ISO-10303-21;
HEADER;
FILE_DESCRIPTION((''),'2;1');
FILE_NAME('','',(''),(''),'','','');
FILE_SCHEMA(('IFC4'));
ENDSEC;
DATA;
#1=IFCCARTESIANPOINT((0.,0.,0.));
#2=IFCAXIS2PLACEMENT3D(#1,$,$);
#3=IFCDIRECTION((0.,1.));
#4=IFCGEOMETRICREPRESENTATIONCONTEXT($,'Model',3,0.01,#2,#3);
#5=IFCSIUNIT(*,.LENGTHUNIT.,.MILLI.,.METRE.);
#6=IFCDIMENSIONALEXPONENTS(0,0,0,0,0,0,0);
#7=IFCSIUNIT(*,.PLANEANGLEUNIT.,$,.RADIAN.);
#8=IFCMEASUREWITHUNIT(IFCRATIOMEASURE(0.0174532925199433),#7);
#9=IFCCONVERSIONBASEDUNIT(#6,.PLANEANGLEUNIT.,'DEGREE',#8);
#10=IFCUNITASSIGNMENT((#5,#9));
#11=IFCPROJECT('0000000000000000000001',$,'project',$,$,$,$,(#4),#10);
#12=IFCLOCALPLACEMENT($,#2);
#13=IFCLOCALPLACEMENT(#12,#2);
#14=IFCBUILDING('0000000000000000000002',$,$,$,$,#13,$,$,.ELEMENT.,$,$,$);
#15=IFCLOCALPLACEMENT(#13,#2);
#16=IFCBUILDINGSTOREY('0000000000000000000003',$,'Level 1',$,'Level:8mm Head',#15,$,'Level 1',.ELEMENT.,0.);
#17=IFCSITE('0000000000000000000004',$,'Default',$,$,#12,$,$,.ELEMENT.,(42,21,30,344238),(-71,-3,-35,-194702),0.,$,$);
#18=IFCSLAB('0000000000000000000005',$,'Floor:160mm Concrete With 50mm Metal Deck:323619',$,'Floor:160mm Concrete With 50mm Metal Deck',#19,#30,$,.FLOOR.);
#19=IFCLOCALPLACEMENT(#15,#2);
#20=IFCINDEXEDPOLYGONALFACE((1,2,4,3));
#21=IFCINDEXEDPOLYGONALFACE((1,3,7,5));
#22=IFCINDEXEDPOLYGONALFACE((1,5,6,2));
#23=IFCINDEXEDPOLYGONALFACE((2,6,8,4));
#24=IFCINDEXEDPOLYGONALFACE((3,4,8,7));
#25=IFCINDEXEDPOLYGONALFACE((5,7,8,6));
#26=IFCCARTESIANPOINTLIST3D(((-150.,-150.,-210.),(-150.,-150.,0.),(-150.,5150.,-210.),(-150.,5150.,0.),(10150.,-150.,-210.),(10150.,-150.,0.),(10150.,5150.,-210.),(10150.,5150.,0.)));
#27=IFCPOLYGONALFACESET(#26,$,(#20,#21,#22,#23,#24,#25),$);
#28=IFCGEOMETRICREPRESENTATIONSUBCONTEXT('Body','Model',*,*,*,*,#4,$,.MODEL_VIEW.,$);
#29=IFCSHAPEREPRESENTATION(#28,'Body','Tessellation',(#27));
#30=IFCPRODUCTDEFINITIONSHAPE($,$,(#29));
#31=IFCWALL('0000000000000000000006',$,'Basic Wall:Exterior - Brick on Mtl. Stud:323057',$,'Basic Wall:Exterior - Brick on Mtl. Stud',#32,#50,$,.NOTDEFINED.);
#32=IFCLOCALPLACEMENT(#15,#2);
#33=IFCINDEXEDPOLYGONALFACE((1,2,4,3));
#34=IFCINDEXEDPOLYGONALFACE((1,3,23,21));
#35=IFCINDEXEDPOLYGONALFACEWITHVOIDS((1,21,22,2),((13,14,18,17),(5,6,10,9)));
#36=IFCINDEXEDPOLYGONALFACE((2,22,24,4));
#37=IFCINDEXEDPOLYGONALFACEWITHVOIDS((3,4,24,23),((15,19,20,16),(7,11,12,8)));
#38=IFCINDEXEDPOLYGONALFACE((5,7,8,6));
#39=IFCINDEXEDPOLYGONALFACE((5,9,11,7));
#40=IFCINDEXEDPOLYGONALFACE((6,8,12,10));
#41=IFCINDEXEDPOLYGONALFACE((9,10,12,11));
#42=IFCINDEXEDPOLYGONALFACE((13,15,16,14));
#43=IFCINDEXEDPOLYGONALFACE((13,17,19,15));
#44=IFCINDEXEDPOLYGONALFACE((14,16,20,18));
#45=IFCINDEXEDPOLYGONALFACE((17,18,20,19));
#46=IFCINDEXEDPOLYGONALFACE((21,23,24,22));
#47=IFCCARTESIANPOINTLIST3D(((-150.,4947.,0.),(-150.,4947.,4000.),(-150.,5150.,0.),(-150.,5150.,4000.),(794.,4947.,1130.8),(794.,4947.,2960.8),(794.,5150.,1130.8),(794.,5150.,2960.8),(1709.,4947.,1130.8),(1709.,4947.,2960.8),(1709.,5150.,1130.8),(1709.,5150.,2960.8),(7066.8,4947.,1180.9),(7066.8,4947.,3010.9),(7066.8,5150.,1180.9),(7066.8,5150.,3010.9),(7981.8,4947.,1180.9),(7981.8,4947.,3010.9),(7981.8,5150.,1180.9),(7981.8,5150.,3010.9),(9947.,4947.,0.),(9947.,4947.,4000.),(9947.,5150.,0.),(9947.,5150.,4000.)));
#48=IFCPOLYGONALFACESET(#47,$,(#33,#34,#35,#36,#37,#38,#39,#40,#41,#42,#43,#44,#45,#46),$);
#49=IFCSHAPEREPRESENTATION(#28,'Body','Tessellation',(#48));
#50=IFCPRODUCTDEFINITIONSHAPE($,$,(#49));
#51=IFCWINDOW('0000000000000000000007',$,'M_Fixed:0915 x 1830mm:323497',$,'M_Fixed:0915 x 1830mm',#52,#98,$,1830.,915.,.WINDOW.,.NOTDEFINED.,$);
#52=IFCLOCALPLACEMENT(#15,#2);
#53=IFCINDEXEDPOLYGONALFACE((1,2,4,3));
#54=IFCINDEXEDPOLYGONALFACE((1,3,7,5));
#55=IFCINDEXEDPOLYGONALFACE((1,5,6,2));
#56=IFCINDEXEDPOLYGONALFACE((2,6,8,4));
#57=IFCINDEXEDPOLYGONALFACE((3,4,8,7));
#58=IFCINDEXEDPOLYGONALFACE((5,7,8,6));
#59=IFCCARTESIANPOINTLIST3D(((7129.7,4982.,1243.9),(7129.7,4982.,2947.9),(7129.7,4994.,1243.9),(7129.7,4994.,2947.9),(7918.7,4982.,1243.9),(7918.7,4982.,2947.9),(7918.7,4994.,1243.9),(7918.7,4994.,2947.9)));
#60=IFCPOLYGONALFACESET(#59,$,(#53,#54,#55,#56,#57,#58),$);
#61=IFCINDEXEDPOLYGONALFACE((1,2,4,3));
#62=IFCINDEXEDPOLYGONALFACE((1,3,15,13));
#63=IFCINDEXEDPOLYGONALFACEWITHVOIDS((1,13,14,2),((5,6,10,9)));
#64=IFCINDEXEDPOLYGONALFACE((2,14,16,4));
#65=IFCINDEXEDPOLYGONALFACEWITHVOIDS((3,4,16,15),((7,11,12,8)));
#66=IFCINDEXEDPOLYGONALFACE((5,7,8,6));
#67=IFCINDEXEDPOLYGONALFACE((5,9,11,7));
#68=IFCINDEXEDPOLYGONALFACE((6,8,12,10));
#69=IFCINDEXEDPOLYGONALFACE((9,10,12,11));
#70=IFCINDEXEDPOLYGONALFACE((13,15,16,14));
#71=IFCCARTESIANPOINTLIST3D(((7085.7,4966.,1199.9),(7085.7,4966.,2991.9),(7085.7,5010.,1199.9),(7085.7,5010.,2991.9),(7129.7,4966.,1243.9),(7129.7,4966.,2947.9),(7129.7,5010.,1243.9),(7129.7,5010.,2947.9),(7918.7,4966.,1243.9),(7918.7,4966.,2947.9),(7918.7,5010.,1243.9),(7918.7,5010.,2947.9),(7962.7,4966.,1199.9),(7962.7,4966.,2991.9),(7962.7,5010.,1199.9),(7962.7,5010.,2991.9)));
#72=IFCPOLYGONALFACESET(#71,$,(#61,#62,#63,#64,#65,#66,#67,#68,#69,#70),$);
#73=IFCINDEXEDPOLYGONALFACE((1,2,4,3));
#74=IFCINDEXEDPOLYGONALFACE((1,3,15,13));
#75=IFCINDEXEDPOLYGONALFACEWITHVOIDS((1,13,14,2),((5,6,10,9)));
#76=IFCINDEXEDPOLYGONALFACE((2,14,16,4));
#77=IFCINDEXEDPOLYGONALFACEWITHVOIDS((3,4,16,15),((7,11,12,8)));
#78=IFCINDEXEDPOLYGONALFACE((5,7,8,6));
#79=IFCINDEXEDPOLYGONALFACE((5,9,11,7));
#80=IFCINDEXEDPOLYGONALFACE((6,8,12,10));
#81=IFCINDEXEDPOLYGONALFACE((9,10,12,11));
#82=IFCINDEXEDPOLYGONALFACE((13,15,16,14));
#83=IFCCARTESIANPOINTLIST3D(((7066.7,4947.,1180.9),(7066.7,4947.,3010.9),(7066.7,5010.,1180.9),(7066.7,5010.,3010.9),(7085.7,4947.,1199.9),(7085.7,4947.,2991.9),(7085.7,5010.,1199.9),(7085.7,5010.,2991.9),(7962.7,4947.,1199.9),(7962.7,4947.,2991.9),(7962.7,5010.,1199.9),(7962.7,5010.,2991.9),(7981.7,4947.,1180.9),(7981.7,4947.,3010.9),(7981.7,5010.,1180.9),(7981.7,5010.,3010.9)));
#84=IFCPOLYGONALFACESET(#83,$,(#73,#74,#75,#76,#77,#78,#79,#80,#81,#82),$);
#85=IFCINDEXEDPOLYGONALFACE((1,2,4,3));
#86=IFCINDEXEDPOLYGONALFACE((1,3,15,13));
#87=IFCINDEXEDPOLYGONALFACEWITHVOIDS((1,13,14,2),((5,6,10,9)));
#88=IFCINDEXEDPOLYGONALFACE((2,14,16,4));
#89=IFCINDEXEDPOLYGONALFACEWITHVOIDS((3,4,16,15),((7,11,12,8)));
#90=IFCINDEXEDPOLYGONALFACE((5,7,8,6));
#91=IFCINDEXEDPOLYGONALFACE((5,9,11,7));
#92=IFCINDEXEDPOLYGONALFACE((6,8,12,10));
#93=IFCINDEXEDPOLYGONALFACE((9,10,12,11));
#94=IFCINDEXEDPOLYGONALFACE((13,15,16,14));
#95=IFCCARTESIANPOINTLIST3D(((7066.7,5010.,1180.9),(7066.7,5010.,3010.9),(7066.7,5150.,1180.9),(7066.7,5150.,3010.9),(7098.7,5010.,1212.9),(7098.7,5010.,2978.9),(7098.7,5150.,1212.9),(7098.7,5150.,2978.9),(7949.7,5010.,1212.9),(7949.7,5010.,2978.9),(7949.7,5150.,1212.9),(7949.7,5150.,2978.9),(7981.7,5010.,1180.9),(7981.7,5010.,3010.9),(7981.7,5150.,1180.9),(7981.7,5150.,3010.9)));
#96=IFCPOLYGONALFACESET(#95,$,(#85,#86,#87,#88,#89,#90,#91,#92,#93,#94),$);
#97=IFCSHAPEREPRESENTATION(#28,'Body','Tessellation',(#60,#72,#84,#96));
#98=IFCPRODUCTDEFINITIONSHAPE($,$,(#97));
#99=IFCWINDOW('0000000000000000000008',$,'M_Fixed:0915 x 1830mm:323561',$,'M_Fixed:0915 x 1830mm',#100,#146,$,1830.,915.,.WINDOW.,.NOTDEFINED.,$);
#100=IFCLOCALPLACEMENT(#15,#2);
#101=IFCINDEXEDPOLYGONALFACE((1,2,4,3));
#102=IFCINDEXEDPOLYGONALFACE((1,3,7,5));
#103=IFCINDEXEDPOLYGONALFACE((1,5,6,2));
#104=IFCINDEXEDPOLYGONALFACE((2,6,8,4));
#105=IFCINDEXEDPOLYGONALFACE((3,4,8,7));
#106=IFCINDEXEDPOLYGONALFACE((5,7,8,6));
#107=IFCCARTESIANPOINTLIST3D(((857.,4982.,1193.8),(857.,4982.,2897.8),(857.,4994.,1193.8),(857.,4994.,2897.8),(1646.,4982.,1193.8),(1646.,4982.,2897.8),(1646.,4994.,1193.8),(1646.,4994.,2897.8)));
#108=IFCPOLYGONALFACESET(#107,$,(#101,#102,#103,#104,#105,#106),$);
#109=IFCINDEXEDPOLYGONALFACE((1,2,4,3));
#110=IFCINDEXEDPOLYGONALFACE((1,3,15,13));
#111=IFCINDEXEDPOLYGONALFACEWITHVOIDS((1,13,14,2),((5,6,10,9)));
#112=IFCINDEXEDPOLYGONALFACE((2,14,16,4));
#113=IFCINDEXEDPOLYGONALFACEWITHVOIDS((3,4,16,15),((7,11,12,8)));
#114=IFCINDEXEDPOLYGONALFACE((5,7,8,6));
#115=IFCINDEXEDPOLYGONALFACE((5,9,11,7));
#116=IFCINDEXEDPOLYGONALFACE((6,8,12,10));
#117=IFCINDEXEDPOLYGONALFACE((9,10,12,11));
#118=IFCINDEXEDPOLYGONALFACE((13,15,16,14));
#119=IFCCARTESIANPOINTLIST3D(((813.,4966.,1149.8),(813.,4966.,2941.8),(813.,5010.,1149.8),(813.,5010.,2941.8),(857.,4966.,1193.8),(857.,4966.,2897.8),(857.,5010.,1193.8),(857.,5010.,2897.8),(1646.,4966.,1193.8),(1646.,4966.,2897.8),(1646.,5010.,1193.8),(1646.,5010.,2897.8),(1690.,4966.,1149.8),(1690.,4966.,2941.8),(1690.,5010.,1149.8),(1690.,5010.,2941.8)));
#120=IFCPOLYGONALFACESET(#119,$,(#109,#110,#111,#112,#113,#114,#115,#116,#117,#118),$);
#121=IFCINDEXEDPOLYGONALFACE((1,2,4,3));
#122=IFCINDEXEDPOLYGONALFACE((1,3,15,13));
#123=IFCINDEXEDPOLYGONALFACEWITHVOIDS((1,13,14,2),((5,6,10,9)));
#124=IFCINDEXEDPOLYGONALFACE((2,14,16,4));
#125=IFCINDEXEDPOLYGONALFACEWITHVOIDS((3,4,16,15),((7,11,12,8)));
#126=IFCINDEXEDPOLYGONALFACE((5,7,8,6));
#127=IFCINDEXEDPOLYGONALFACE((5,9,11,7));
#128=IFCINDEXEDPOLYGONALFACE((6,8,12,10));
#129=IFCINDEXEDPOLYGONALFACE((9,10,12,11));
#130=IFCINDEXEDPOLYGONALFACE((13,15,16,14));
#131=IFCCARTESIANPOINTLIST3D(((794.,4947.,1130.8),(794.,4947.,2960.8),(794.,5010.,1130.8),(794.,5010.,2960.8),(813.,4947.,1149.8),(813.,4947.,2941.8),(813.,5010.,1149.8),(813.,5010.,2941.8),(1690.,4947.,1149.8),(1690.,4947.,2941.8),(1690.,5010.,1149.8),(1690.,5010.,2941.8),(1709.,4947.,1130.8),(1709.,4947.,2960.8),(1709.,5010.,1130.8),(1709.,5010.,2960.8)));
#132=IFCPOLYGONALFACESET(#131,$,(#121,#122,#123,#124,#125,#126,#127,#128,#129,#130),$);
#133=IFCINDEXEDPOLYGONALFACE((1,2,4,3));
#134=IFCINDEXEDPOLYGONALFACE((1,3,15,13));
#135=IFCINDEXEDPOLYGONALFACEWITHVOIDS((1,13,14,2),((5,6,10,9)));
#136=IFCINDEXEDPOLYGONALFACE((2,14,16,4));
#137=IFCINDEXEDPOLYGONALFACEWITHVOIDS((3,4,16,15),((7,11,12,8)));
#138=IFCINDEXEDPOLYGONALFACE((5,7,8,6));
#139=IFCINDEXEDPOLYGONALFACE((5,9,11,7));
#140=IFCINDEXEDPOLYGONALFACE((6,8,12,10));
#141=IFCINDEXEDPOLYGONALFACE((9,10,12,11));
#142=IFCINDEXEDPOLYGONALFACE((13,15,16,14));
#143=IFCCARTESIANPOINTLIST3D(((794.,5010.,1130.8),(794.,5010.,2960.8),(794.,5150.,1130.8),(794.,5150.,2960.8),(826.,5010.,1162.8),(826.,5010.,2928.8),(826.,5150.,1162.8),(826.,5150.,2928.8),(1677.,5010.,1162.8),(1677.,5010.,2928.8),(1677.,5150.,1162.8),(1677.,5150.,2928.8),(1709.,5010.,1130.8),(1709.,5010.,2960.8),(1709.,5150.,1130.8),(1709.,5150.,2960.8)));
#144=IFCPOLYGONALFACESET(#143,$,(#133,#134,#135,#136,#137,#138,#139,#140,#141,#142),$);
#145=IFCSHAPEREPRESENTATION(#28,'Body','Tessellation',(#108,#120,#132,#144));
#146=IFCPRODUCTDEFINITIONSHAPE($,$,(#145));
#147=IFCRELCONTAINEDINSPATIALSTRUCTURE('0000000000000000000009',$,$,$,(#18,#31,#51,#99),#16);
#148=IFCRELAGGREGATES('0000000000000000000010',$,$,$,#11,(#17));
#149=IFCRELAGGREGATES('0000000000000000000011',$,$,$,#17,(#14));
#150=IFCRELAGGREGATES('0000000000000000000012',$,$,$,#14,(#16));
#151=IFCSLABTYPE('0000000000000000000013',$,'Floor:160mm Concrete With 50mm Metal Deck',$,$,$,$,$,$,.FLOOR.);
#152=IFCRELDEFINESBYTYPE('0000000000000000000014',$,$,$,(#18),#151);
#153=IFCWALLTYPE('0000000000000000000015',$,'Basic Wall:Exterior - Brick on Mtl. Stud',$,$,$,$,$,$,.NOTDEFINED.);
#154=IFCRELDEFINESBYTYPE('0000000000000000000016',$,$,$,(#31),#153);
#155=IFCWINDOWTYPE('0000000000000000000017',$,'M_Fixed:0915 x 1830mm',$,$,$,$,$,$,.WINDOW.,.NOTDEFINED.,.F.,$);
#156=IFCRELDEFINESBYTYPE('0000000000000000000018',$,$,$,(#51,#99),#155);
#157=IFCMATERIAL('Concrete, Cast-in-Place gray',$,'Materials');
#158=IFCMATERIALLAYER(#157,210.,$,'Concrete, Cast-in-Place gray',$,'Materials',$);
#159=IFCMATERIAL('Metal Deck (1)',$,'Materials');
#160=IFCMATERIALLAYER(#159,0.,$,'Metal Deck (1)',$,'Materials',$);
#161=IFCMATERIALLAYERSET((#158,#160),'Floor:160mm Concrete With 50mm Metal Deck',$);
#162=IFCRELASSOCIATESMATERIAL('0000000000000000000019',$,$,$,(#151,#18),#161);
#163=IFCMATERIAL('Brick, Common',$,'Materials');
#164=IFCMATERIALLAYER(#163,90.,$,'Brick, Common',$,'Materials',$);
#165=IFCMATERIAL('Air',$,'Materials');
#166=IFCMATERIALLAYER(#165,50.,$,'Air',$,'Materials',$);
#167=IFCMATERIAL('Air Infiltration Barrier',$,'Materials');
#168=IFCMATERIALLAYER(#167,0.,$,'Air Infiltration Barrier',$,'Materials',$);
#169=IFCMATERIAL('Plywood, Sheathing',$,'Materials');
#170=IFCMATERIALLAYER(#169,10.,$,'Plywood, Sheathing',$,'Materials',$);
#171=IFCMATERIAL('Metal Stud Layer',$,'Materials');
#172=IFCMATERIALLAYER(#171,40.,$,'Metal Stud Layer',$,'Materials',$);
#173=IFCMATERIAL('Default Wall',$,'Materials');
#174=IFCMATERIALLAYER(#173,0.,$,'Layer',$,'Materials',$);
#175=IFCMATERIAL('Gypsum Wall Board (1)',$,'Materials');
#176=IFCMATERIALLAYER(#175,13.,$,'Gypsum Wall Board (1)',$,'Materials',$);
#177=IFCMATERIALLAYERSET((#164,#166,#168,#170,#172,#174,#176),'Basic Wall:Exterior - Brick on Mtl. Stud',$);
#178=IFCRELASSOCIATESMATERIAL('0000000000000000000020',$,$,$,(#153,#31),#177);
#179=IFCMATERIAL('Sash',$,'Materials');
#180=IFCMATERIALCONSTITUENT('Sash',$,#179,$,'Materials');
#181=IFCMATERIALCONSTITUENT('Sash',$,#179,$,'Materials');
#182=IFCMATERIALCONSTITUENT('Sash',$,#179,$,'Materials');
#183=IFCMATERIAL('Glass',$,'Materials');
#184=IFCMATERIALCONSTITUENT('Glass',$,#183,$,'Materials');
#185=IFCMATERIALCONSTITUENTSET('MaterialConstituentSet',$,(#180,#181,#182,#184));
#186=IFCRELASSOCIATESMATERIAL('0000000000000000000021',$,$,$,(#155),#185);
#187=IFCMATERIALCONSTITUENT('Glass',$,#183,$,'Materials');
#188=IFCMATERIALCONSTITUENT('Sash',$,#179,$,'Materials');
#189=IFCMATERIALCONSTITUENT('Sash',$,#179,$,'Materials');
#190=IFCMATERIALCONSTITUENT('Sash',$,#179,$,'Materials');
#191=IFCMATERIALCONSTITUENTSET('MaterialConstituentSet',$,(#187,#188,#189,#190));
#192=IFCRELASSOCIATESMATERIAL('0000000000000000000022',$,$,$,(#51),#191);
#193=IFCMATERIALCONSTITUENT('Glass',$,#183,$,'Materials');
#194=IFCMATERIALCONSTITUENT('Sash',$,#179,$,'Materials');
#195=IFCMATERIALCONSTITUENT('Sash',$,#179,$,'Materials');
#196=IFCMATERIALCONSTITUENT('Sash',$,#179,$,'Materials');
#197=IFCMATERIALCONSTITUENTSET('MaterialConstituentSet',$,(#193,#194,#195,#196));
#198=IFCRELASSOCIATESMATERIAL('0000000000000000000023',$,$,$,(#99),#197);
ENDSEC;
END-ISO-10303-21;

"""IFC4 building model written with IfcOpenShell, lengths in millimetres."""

from ifc_helpers import new_model, entity, si_unit, converted_unit, direction, frame, frame_2d, origin, place, context, subcontext, project, spatial, polyline, rectangle, outline, extrude, source, transform, mapped, material, layer, layer_set, layer_usage, constituent, constituent_set, type_object, type_shapes, element, fill, save


model = new_model("IFC4")

# Units and contexts
model_context = context("Model", 3, precision=0.01, world=origin(), true_north=direction((0.0, 1.0)))
body_context = subcontext(model_context, "Body", "Model", "MODEL_VIEW")
ifc_project = project(units=[si_unit("LENGTHUNIT", "METRE", prefix="MILLI"), converted_unit("PLANEANGLEUNIT", "DEGREE", entity("IfcRatioMeasure", 0.0174532925199433), si_unit("PLANEANGLEUNIT", "RADIAN"), dimensions=[0, 0, 0, 0, 0, 0, 0])], contexts=[model_context])

# Site, building, storey
site_placement = place(None, origin())
site = spatial("IfcSite", under=ifc_project, at=site_placement, Name="Default", CompositionType="ELEMENT", RefLatitude=(42, 21, 30, 344238), RefLongitude=(-71, -3, -35, -194702), RefElevation=0.0)
building_placement = place(site_placement, origin())
building = spatial("IfcBuilding", under=site, at=building_placement, CompositionType="ELEMENT")
storey_placement = place(building_placement, origin())
storey = spatial("IfcBuildingStorey", under=building, at=storey_placement, Name="Level 1", ObjectType="Level:8mm Head", LongName="Level 1", CompositionType="ELEMENT", Elevation=0.0)

# Slab
ifc_material_1 = material(Name="Concrete, Cast-in-Place gray", Category="Materials")
ifc_layer_1 = layer(ifc_material_1, 210.0, Name="Concrete, Cast-in-Place gray", Category="Materials")
ifc_material_2 = material(Name="Metal Deck (1)", Category="Materials")
ifc_layer_2 = layer(ifc_material_2, 0.0, Name="Metal Deck (1)", Category="Materials")
ifc_layer_set_1 = layer_set([ifc_layer_1, ifc_layer_2], Name="Floor:160mm Concrete With 50mm Metal Deck")
ifc_layer_usage_1 = layer_usage(ifc_layer_set_1, "AXIS3", "POSITIVE", 0.0)
slab_type = type_object("IfcSlabType", Name="Floor:160mm Concrete With 50mm Metal Deck", PredefinedType="FLOOR", material=ifc_layer_set_1)
slab_placement = place(storey_placement, origin())
element("IfcSlab", 1, at=slab_placement, inside=storey, type_object=slab_type, material=ifc_layer_usage_1, Name="Floor:160mm Concrete With 50mm Metal Deck:323619", ObjectType="Floor:160mm Concrete With 50mm Metal Deck", PredefinedType="FLOOR", context=body_context, shape_type="SweptSolid", body=[
    extrude(rectangle(XDim=5300.0, YDim=10300.0, at=frame_2d((0.0, 0.0), x_axis=(1.0, 0.0))), frame((5000.0, 2500.0, 0.0), z_axis=(0.0, 0.0, -1.0), x_axis=(0.0, 1.0, 0.0)), (0.0, 0.0, 1.0), 210.0),
])

# Wall, openings, windows
ifc_material_3 = material(Name="Brick, Common", Category="Materials")
ifc_layer_3 = layer(ifc_material_3, 90.0, Name="Brick, Common", Category="Materials")
ifc_material_4 = material(Name="Air", Category="Materials")
ifc_layer_4 = layer(ifc_material_4, 50.0, Name="Air", Category="Materials")
ifc_material_5 = material(Name="Air Infiltration Barrier", Category="Materials")
ifc_layer_5 = layer(ifc_material_5, 0.0, Name="Air Infiltration Barrier", Category="Materials")
ifc_material_6 = material(Name="Plywood, Sheathing", Category="Materials")
ifc_layer_6 = layer(ifc_material_6, 10.0, Name="Plywood, Sheathing", Category="Materials")
ifc_material_7 = material(Name="Metal Stud Layer", Category="Materials")
ifc_layer_7 = layer(ifc_material_7, 40.0, Name="Metal Stud Layer", Category="Materials")
ifc_material_8 = material(Name="Default Wall", Category="Materials")
ifc_layer_8 = layer(ifc_material_8, 0.0, Name="Layer", Category="Materials")
ifc_material_9 = material(Name="Gypsum Wall Board (1)", Category="Materials")
ifc_layer_9 = layer(ifc_material_9, 13.0, Name="Gypsum Wall Board (1)", Category="Materials")
ifc_layer_set_2 = layer_set([ifc_layer_3, ifc_layer_4, ifc_layer_5, ifc_layer_6, ifc_layer_7, ifc_layer_8, ifc_layer_9], Name="Basic Wall:Exterior - Brick on Mtl. Stud")
ifc_layer_usage_2 = layer_usage(ifc_layer_set_2, "AXIS2", "NEGATIVE", 101.5)
wall_type_1 = type_object("IfcWallType", Name="Basic Wall:Exterior - Brick on Mtl. Stud", PredefinedType="NOTDEFINED", material=ifc_layer_set_2)
wall_1_placement = place(storey_placement, frame((-150.0, 5048.5, 0.0)))
wall_1 = element("IfcWall", 2, at=wall_1_placement, inside=storey, type_object=wall_type_1, material=ifc_layer_usage_2, Name="Basic Wall:Exterior - Brick on Mtl. Stud:323057", ObjectType="Basic Wall:Exterior - Brick on Mtl. Stud", PredefinedType="NOTDEFINED", context=body_context, shape_type="SweptSolid", body=[
    extrude(rectangle(XDim=10097.0, YDim=203.0, at=frame_2d((5048.5, 0.0), x_axis=(-1.0, 0.0))), origin(), (0.0, 0.0, 1.0), 4000.0),
])
opening_1_placement = place(wall_1_placement, frame((8131.8, 101.5, 1180.9)))
opening_1 = element("IfcOpeningElement", 3, at=opening_1_placement, cuts=wall_1, ObjectType="Opening", PredefinedType="OPENING", context=body_context, shape_type="SweptSolid", body=[
    extrude(rectangle(XDim=1830.0, YDim=915.0, at=frame_2d((915.0, 457.5), x_axis=(1.0, 0.0))), frame((0.0, 0.0, 0.0), z_axis=(0.0, -1.0, 0.0), x_axis=(0.0, 0.0, 1.0)), (0.0, 0.0, 1.0), 203.0),
])
opening_2_placement = place(wall_1_placement, frame((1859.0, 101.5, 1130.8)))
opening_2 = element("IfcOpeningElement", 4, at=opening_2_placement, cuts=wall_1, ObjectType="Opening", PredefinedType="OPENING", context=body_context, shape_type="SweptSolid", body=[
    extrude(rectangle(XDim=1830.0, YDim=915.0, at=frame_2d((915.0, 457.5), x_axis=(1.0, 0.0))), frame((0.0, 0.0, 0.0), z_axis=(0.0, -1.0, 0.0), x_axis=(0.0, 0.0, 1.0)), (0.0, 0.0, 1.0), 203.0),
])
ifc_material_10 = material(Name="Glass", Category="Materials")
ifc_constituent_1 = constituent(ifc_material_10, Name="Glass", Category="Materials")
ifc_material_11 = material(Name="Sash", Category="Materials")
ifc_constituent_2 = constituent(ifc_material_11, Name="Sash", Category="Materials")
ifc_constituent_3 = constituent(ifc_material_11, Name="Sash", Category="Materials")
ifc_constituent_4 = constituent(ifc_material_11, Name="Sash", Category="Materials")
ifc_constituent_set_1 = constituent_set(constituents=[ifc_constituent_1, ifc_constituent_2, ifc_constituent_3, ifc_constituent_4], Name="MaterialConstituentSet")
ifc_constituent_5 = constituent(ifc_material_11, Name="Sash", Category="Materials")
ifc_constituent_6 = constituent(ifc_material_11, Name="Sash", Category="Materials")
ifc_constituent_7 = constituent(ifc_material_11, Name="Sash", Category="Materials")
ifc_constituent_8 = constituent(ifc_material_10, Name="Glass", Category="Materials")
ifc_constituent_set_2 = constituent_set(constituents=[ifc_constituent_5, ifc_constituent_6, ifc_constituent_7, ifc_constituent_8], Name="MaterialConstituentSet")
window_type = type_object("IfcWindowType", Name="M_Fixed:0915 x 1830mm", ParameterTakesPrecedence=False, PartitioningType="NOTDEFINED", PredefinedType="WINDOW", material=ifc_constituent_set_2)
shared_shape_1 = source(origin(), body_context, "Body", "SweptSolid", [
    extrude(rectangle(XDim=12.0, YDim=789.0, at=frame_2d((0.0, 0.0), x_axis=(1.0, 0.0))), frame((457.5, 162.0, 63.0), z_axis=(0.0, 0.0, 1.0), x_axis=(0.0, -1.0, 0.0)), (0.0, 0.0, 1.0), 1704.0),
    extrude(outline(polyline([(-438.5, -896.0), (438.5, -896.0), (438.5, 896.0), (-438.5, 896.0), (-438.5, -896.0)]), holes=[polyline([(-394.5, -852.0), (-394.5, 852.0), (394.5, 852.0), (394.5, -852.0), (-394.5, -852.0)])]), frame((457.5, 140.0, 915.0), z_axis=(0.0, 1.0, 0.0), x_axis=(1.0, 0.0, 0.0)), (0.0, 0.0, 1.0), 44.0),
    extrude(outline(polyline([(-457.5, -915.0), (457.5, -915.0), (457.5, 915.0), (-457.5, 915.0), (-457.5, -915.0)]), holes=[polyline([(-438.5, -896.0), (-438.5, 896.0), (438.5, 896.0), (438.5, -896.0), (-438.5, -896.0)])]), frame((457.5, 140.0, 915.0), z_axis=(0.0, 1.0, 0.0), x_axis=(1.0, 0.0, 0.0)), (0.0, 0.0, 1.0), 63.0),
    extrude(outline(polyline([(-457.5, -915.0), (457.5, -915.0), (457.5, 915.0), (-457.5, 915.0), (-457.5, -915.0)]), holes=[polyline([(-425.5, -883.0), (-425.5, 883.0), (425.5, 883.0), (425.5, -883.0), (-425.5, -883.0)])]), frame((457.5, 0.0, 915.0), z_axis=(0.0, 1.0, 0.0), x_axis=(1.0, 0.0, 0.0)), (0.0, 0.0, 1.0), 140.0),
])
type_shapes(window_type, [shared_shape_1])
window_1_placement = place(opening_1_placement, frame((0.0, 0.0, 0.0), z_axis=(0.0, 0.0, 1.0), x_axis=(-1.0, 0.0, 0.0)))
window_1 = element("IfcWindow", 5, at=window_1_placement, inside=storey, type_object=window_type, material=ifc_constituent_set_1, Name="M_Fixed:0915 x 1830mm:323497", ObjectType="M_Fixed:0915 x 1830mm", OverallHeight=1830.0, OverallWidth=915.0, PartitioningType="NOTDEFINED", PredefinedType="WINDOW", context=body_context, shape_type="MappedRepresentation", body=[
    mapped(shared_shape_1, transform((0.0, 0.0, 0.0), scale=1.0)),
])
fill(opening_1, window_1)
ifc_constituent_9 = constituent(ifc_material_10, Name="Glass", Category="Materials")
ifc_constituent_10 = constituent(ifc_material_11, Name="Sash", Category="Materials")
ifc_constituent_11 = constituent(ifc_material_11, Name="Sash", Category="Materials")
ifc_constituent_12 = constituent(ifc_material_11, Name="Sash", Category="Materials")
ifc_constituent_set_3 = constituent_set(constituents=[ifc_constituent_9, ifc_constituent_10, ifc_constituent_11, ifc_constituent_12], Name="MaterialConstituentSet")
window_2_placement = place(opening_2_placement, frame((0.0, 0.0, 0.0), z_axis=(0.0, 0.0, 1.0), x_axis=(-1.0, 0.0, 0.0)))
window_2 = element("IfcWindow", 6, at=window_2_placement, inside=storey, type_object=window_type, material=ifc_constituent_set_3, Name="M_Fixed:0915 x 1830mm:323561", ObjectType="M_Fixed:0915 x 1830mm", OverallHeight=1830.0, OverallWidth=915.0, PartitioningType="NOTDEFINED", PredefinedType="WINDOW", context=body_context, shape_type="MappedRepresentation", body=[
    mapped(shared_shape_1, transform((0.0, 0.0, 0.0), scale=1.0)),
])
fill(opening_2, window_2)

save(model, "model.ifc")
